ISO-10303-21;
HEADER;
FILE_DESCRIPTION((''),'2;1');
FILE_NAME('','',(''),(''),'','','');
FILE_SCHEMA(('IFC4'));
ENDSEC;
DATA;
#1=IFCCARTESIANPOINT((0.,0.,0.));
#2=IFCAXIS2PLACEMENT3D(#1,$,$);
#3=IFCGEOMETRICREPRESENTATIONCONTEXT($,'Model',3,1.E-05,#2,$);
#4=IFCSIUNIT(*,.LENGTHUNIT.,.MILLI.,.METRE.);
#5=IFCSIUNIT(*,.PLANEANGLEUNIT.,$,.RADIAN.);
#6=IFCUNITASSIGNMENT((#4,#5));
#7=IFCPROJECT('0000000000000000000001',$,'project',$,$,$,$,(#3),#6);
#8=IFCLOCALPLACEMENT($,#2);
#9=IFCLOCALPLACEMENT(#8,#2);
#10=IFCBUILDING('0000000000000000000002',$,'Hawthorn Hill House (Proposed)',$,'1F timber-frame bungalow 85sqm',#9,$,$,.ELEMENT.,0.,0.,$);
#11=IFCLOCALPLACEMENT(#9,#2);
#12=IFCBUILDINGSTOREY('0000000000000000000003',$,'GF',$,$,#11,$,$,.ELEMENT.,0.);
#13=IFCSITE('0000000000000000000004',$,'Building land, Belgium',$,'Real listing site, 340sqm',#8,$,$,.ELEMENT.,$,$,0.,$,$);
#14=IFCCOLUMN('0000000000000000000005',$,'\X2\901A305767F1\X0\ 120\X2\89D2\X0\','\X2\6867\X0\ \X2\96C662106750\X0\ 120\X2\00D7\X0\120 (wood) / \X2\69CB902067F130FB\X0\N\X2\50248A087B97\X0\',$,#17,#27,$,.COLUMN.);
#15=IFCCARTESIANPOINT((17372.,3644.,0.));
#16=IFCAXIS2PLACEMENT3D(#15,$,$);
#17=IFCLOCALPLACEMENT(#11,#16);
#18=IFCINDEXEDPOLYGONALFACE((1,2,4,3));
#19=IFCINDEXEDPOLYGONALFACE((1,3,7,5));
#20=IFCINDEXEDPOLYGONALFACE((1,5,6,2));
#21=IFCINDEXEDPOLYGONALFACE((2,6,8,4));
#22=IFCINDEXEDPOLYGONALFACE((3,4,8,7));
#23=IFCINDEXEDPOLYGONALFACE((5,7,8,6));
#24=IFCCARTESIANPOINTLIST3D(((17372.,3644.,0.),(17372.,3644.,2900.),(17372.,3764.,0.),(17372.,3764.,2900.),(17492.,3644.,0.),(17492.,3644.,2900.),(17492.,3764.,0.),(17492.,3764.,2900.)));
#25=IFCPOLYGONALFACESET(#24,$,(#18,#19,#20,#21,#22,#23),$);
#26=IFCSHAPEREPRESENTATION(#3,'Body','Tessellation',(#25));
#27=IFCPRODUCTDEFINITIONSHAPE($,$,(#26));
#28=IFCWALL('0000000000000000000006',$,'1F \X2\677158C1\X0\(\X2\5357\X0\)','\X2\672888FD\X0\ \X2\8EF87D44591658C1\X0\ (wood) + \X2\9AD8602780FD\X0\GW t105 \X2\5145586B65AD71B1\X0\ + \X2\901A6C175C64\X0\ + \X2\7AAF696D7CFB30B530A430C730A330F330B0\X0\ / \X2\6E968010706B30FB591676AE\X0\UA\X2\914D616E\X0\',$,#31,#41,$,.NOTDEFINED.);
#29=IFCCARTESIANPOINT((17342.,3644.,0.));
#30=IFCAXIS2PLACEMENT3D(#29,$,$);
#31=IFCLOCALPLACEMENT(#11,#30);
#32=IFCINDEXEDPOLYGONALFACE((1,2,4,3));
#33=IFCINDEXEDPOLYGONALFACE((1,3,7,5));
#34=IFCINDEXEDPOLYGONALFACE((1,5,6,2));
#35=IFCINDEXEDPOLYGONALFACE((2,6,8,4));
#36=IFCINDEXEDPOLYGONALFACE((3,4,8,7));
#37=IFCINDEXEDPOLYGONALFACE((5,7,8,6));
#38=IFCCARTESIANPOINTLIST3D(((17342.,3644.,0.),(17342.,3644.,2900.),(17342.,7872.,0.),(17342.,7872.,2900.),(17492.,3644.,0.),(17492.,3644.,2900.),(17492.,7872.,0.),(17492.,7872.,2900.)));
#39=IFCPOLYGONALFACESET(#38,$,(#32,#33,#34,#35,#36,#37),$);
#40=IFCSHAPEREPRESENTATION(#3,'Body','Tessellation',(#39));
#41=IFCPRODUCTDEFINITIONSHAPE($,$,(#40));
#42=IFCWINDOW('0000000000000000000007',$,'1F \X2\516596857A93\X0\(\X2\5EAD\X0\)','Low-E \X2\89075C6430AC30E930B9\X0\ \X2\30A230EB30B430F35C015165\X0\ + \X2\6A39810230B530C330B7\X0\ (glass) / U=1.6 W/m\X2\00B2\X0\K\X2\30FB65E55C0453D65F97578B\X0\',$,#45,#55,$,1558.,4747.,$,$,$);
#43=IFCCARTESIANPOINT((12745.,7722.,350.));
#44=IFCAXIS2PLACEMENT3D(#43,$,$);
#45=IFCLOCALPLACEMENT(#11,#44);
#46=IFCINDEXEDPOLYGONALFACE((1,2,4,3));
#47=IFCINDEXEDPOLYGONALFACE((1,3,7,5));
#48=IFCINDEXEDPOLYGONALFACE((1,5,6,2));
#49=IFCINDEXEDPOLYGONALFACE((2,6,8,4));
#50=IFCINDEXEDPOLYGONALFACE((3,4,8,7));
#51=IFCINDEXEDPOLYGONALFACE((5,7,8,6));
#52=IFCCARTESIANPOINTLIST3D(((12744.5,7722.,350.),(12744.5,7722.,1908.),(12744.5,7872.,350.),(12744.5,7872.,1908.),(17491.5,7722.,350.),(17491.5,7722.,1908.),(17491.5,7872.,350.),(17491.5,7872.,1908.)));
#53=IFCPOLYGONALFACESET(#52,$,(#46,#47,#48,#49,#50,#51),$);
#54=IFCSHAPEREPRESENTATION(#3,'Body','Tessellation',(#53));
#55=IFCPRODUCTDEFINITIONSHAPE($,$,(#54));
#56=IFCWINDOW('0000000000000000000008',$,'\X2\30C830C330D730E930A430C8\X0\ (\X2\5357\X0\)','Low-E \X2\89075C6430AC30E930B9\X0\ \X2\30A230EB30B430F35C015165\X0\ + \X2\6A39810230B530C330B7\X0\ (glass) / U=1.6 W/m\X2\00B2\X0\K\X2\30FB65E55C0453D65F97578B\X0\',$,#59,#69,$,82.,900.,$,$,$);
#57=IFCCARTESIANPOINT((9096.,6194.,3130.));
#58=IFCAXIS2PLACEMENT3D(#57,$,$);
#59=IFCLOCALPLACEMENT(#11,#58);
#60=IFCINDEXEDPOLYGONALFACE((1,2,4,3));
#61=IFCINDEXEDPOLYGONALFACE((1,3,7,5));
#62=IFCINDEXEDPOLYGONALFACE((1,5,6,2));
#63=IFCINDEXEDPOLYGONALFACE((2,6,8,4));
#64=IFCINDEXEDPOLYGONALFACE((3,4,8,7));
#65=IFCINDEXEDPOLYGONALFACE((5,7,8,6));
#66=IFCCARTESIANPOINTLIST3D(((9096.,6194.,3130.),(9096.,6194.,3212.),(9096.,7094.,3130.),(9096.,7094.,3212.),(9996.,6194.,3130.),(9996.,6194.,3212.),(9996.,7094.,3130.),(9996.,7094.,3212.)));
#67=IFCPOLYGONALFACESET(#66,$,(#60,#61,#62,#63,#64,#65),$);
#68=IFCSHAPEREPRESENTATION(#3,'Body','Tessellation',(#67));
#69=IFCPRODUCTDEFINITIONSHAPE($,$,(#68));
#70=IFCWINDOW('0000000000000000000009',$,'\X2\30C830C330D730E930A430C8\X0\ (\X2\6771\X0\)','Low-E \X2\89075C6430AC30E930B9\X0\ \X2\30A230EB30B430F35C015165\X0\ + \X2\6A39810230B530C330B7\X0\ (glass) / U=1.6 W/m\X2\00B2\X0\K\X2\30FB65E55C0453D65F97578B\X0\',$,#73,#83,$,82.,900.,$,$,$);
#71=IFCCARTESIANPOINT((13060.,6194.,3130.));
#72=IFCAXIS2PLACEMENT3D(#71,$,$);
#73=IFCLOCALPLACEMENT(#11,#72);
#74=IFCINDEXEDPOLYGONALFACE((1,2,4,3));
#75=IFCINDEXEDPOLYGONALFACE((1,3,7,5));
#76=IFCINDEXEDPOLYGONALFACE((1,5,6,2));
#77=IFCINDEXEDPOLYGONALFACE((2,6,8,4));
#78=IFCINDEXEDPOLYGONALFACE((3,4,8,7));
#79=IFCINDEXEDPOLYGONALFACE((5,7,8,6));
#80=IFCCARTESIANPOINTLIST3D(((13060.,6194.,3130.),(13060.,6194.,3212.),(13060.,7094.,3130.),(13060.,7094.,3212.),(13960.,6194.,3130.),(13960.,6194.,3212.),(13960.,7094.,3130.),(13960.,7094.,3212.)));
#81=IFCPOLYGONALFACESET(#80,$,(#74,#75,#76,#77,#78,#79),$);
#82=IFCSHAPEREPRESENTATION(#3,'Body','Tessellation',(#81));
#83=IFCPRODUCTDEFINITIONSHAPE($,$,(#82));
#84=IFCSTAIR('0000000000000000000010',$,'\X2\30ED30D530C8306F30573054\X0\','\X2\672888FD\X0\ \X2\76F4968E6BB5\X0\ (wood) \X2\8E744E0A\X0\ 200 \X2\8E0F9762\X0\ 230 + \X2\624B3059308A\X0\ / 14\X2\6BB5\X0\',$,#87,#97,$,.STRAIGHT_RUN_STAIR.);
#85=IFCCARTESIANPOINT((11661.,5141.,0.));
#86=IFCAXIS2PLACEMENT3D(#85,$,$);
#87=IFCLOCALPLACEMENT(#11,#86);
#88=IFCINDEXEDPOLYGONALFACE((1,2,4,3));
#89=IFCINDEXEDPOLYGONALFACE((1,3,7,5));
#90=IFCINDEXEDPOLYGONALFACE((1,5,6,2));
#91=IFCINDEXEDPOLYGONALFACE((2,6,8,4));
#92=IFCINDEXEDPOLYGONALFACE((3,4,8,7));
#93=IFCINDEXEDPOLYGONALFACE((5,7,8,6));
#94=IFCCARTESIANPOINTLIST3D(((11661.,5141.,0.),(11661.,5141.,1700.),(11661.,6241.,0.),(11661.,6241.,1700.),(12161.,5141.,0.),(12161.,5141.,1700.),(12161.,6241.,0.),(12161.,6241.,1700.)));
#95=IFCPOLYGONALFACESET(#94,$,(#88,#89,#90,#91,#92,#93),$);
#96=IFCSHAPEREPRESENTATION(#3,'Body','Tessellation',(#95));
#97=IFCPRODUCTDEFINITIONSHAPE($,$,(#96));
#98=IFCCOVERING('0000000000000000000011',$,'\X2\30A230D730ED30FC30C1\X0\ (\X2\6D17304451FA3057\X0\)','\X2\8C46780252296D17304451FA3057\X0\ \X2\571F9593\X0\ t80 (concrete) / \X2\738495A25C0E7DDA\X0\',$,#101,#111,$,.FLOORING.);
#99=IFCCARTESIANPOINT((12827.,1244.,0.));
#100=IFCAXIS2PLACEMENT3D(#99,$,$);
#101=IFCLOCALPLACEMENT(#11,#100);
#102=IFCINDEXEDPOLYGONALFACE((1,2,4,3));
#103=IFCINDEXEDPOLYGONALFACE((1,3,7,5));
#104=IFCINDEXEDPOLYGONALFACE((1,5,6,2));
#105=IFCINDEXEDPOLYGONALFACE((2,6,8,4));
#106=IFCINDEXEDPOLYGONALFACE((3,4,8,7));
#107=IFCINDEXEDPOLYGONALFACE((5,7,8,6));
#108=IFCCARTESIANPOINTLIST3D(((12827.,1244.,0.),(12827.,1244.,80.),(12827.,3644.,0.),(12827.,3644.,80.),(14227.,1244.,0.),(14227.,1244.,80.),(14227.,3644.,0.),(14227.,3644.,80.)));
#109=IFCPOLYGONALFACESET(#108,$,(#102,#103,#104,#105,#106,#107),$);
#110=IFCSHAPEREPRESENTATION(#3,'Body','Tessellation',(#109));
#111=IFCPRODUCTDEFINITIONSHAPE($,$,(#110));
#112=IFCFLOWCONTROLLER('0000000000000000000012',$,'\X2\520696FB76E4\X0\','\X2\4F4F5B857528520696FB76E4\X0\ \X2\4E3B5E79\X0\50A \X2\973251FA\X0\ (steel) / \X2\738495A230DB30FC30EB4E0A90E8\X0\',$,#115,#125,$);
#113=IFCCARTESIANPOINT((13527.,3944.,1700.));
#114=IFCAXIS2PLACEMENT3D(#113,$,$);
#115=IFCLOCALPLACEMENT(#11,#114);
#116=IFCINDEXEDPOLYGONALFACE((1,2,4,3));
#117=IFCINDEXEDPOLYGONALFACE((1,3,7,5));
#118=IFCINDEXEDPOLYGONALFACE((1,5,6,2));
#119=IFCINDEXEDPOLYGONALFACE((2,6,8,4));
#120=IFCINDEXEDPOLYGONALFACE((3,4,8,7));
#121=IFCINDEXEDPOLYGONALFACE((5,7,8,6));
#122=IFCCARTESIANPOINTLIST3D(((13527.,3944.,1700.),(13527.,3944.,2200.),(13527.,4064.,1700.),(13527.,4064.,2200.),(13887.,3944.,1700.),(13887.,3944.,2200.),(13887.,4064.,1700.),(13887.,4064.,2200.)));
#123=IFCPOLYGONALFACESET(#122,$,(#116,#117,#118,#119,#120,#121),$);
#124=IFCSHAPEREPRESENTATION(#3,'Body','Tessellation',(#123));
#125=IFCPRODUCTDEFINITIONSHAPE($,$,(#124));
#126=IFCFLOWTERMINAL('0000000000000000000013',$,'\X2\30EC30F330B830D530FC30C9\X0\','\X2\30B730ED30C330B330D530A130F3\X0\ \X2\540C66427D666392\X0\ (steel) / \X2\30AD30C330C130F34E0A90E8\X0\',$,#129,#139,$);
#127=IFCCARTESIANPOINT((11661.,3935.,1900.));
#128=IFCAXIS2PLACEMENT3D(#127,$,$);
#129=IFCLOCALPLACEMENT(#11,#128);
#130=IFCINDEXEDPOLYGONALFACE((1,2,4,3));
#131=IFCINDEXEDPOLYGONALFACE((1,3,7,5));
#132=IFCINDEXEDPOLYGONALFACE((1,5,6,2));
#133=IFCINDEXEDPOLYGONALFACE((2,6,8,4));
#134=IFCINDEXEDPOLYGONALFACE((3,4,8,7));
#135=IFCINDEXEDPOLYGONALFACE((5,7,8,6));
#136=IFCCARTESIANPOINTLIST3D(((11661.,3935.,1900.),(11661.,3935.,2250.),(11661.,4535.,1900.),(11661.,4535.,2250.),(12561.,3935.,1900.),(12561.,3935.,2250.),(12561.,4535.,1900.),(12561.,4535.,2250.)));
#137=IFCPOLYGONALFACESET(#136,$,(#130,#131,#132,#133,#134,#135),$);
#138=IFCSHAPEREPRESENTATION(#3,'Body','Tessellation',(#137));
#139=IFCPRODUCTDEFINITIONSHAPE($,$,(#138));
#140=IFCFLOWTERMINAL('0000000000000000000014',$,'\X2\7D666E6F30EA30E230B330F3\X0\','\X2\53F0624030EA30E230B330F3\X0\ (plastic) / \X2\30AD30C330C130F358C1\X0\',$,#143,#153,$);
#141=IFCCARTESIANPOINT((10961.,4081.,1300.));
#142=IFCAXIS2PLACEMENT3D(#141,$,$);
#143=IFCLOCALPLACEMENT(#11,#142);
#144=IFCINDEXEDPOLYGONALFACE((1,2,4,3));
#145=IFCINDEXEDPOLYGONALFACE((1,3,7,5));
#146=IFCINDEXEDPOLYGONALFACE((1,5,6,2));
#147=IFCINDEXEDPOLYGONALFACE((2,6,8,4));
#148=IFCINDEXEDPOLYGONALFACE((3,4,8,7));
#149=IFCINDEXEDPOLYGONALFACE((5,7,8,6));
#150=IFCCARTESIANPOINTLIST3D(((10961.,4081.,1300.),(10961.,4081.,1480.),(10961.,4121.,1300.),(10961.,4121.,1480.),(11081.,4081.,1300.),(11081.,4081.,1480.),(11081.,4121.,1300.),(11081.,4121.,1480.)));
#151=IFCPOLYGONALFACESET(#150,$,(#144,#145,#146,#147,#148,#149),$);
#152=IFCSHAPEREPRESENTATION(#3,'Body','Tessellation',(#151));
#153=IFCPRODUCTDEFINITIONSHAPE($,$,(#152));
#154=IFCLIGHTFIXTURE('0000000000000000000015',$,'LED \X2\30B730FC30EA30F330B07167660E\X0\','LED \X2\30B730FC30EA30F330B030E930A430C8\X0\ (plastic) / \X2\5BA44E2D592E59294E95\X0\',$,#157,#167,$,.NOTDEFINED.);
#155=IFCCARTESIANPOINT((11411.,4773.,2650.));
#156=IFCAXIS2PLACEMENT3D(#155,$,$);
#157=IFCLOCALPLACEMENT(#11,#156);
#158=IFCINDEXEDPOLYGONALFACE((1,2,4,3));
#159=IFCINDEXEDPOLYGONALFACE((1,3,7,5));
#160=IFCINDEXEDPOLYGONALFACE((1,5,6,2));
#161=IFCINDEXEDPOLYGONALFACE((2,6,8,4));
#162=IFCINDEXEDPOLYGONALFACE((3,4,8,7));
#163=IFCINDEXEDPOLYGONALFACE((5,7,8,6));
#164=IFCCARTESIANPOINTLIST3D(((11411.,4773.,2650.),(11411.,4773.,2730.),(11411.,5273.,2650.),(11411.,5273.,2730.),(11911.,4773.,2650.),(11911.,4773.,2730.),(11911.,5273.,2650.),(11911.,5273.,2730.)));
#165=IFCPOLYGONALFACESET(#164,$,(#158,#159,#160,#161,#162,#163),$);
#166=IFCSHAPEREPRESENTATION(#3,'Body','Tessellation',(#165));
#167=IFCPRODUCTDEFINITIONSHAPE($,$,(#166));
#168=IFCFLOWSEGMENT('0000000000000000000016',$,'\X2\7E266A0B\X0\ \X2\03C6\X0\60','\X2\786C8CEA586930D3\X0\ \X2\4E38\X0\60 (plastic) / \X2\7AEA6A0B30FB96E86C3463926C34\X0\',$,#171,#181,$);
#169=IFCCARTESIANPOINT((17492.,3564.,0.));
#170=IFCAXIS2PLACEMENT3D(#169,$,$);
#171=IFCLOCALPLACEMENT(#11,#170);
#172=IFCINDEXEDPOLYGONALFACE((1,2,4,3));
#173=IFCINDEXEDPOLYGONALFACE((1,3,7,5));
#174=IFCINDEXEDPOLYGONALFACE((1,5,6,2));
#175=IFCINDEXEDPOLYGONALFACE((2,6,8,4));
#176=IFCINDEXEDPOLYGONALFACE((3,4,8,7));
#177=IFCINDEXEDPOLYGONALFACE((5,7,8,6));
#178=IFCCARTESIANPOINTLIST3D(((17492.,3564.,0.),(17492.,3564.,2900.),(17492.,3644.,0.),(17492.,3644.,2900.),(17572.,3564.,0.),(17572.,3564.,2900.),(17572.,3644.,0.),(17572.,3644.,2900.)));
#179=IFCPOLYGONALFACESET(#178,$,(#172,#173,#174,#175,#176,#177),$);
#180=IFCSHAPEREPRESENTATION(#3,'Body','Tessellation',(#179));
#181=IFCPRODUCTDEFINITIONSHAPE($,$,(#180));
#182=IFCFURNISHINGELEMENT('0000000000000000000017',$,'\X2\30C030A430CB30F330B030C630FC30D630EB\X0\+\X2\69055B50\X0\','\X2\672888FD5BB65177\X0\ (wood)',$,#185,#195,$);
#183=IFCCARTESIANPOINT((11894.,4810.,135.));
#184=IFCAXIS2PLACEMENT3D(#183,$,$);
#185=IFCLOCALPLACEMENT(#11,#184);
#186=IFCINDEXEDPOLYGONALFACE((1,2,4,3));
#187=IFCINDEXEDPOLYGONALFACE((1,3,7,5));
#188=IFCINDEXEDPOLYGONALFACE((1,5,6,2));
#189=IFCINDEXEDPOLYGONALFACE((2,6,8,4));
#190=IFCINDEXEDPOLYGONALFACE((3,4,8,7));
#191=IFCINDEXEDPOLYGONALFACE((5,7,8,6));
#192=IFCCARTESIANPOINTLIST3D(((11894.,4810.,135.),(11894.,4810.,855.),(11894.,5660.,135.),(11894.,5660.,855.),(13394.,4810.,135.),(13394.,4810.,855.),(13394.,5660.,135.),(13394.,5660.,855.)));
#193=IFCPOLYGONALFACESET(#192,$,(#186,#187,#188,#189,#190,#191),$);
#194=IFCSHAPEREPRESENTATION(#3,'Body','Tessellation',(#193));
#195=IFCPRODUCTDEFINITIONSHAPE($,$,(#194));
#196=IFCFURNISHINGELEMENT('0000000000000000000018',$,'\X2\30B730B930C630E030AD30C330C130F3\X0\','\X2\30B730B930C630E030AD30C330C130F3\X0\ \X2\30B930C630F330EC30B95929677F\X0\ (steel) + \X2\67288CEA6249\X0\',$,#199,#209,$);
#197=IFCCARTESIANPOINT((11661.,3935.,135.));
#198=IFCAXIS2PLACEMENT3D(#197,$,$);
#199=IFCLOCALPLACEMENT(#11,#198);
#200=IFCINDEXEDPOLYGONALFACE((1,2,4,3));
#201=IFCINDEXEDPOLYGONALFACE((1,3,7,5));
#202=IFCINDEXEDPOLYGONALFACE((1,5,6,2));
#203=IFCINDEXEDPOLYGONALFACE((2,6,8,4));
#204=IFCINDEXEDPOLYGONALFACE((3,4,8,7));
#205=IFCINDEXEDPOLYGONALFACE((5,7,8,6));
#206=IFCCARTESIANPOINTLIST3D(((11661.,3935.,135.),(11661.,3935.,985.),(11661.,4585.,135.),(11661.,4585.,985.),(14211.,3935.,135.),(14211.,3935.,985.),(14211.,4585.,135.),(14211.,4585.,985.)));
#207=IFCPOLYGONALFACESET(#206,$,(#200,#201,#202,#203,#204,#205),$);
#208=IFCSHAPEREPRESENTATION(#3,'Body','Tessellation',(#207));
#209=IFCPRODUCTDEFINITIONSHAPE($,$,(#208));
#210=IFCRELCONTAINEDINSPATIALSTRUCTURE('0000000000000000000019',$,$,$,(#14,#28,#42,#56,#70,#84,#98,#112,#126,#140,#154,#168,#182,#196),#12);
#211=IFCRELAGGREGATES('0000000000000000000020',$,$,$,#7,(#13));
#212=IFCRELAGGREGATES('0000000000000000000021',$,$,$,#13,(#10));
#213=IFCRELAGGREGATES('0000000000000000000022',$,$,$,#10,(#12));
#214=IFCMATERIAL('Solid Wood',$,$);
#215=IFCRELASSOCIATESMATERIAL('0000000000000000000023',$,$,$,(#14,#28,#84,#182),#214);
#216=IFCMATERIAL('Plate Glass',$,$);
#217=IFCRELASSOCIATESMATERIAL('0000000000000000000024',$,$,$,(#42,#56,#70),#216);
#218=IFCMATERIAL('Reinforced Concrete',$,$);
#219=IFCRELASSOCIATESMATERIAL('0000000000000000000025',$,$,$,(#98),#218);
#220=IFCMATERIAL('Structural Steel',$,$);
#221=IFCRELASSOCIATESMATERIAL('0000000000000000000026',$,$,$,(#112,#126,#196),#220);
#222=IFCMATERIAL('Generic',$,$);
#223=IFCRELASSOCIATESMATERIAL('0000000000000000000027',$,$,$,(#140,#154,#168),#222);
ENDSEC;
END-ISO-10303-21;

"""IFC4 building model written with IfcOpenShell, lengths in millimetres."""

from ifc_helpers import new_model, si_unit, frame, frame_2d, origin, place, context, project, spatial, rectangle, extrude, material, element, fill, save


model = new_model("IFC4")

# Units and contexts
model_context = context("Model", 3, precision=1e-05, world=origin())
ifc_project = project(units=[si_unit("LENGTHUNIT", "METRE", prefix="MILLI"), si_unit("PLANEANGLEUNIT", "RADIAN")], contexts=[model_context])

# Site, building, storey
site_placement = place(None, origin())
site = spatial("IfcSite", under=ifc_project, at=site_placement, Name="Building land, Belgium", ObjectType="Real listing site, 340sqm", CompositionType="ELEMENT", RefElevation=0.0)
building_placement = place(site_placement, origin())
building = spatial("IfcBuilding", under=site, at=building_placement, Name="Hawthorn Hill House (Proposed)", ObjectType="1F timber-frame bungalow 85sqm", CompositionType="ELEMENT", ElevationOfRefHeight=0.0, ElevationOfTerrain=0.0)
storey_placement = place(building_placement, origin())
storey = spatial("IfcBuildingStorey", under=building, at=storey_placement, Name="GF", CompositionType="ELEMENT", Elevation=0.0)

# Column
ifc_material_1 = material(Name="Solid Wood")
column_1_placement = place(storey_placement, frame((17372.0, 3644.0, 0.0)))
element("IfcColumn", 1, at=column_1_placement, inside=storey, material=ifc_material_1, Name="通し柱 120角", Description="桧 集成材 120×120 (wood) / 構造柱・N値計算", PredefinedType="COLUMN", context=model_context, shape_type="SweptSolid", body=[
    extrude(rectangle(XDim=120.0, YDim=120.0, at=frame_2d((60.0, 60.0))), frame((17372.0, 3644.0, 0.0)), (0.0, 0.0, 1.0), 2900.0),
])

# Wall, opening, window
wall_1_placement = place(storey_placement, frame((17342.0, 3644.0, 0.0)))
wall_1 = element("IfcWall", 2, at=wall_1_placement, inside=storey, material=ifc_material_1, Name="1F 東壁(南)", Description="木製 軸組外壁 (wood) + 高性能GW t105 充填断熱 + 通気層 + 窯業系サイディング / 準耐火・外皮UA配慮", PredefinedType="NOTDEFINED", context=model_context, shape_type="SweptSolid", body=[
    extrude(rectangle(XDim=150.0, YDim=4228.0, at=frame_2d((75.0, 2114.0))), frame((17342.0, 3644.0, 0.0)), (0.0, 0.0, 1.0), 2900.0),
])
opening_1_placement = place(storey_placement, frame((12745.0, 7722.0, 350.0)))
opening_1 = element("IfcOpeningElement", 3, at=opening_1_placement, cuts=wall_1, PredefinedType="NOTDEFINED", context=model_context, shape_type="SweptSolid", body=[
    extrude(rectangle(XDim=4747.0, YDim=150.0, at=frame_2d((2373.0, 75.0))), frame((12745.0, 7722.0, 350.0)), (0.0, 0.0, 1.0), 1558.0),
])
ifc_material_2 = material(Name="Plate Glass")
window_1_placement = place(storey_placement, frame((12745.0, 7722.0, 350.0)))
window_1 = element("IfcWindow", 4, at=window_1_placement, inside=storey, material=ifc_material_2, Name="1F 入隅窓(庭)", Description="Low-E 複層ガラス アルゴン封入 + 樹脂サッシ (glass) / U=1.6 W/m²K・日射取得型", OverallHeight=1558.0, OverallWidth=4747.0, context=model_context, shape_type="SweptSolid", body=[
    extrude(rectangle(XDim=4747.0, YDim=150.0, at=frame_2d((2373.0, 75.0))), frame((12745.0, 7722.0, 350.0)), (0.0, 0.0, 1.0), 1558.0),
])
fill(opening_1, window_1)

# Windows
window_2_placement = place(storey_placement, frame((9096.0, 6194.0, 3130.0)))
element("IfcWindow", 5, at=window_2_placement, inside=storey, material=ifc_material_2, Name="トップライト (南)", Description="Low-E 複層ガラス アルゴン封入 + 樹脂サッシ (glass) / U=1.6 W/m²K・日射取得型", OverallHeight=82.0, OverallWidth=900.0, context=model_context, shape_type="SweptSolid", body=[
    extrude(rectangle(XDim=900.0, YDim=900.0, at=frame_2d((450.0, 450.0))), frame((9096.0, 6194.0, 3130.0)), (0.0, 0.0, 1.0), 82.0),
])
window_3_placement = place(storey_placement, frame((13060.0, 6194.0, 3130.0)))
element("IfcWindow", 6, at=window_3_placement, inside=storey, material=ifc_material_2, Name="トップライト (東)", Description="Low-E 複層ガラス アルゴン封入 + 樹脂サッシ (glass) / U=1.6 W/m²K・日射取得型", OverallHeight=82.0, OverallWidth=900.0, context=model_context, shape_type="SweptSolid", body=[
    extrude(rectangle(XDim=900.0, YDim=900.0, at=frame_2d((450.0, 450.0))), frame((13060.0, 6194.0, 3130.0)), (0.0, 0.0, 1.0), 82.0),
])

# Stair
stair_placement = place(storey_placement, frame((11661.0, 5141.0, 0.0)))
element("IfcStair", 7, at=stair_placement, inside=storey, material=ifc_material_1, Name="ロフトはしご", Description="木製 直階段 (wood) 蹴上 200 踏面 230 + 手すり / 14段", PredefinedType="STRAIGHT_RUN_STAIR", context=model_context, shape_type="SweptSolid", body=[
    extrude(rectangle(XDim=500.0, YDim=1100.0, at=frame_2d((250.0, 550.0))), frame((11661.0, 5141.0, 0.0)), (0.0, 0.0, 1.0), 1700.0),
])

# Covering
ifc_material_3 = material(Name="Reinforced Concrete")
covering_placement = place(storey_placement, frame((12827.0, 1244.0, 0.0)))
element("IfcCovering", 8, at=covering_placement, inside=storey, material=ifc_material_3, Name="アプローチ (洗い出し)", Description="豆砂利洗い出し 土間 t80 (concrete) / 玄関導線", PredefinedType="FLOORING", context=model_context, shape_type="SweptSolid", body=[
    extrude(rectangle(XDim=1400.0, YDim=2400.0, at=frame_2d((700.0, 1200.0))), frame((12827.0, 1244.0, 0.0)), (0.0, 0.0, 1.0), 80.0),
])

# Flow controller
ifc_material_4 = material(Name="Structural Steel")
flow_controller_placement = place(storey_placement, frame((13527.0, 3944.0, 1700.0)))
element("IfcFlowController", 9, at=flow_controller_placement, inside=storey, material=ifc_material_4, Name="分電盤", Description="住宅用分電盤 主幹50A 露出 (steel) / 玄関ホール上部", context=model_context, shape_type="SweptSolid", body=[
    extrude(rectangle(XDim=360.0, YDim=120.0, at=frame_2d((180.0, 60.0))), frame((13527.0, 3944.0, 1700.0)), (0.0, 0.0, 1.0), 500.0),
])

# Flow terminals
flow_terminal_1_placement = place(storey_placement, frame((11661.0, 3935.0, 1900.0)))
element("IfcFlowTerminal", 10, at=flow_terminal_1_placement, inside=storey, material=ifc_material_4, Name="レンジフード", Description="シロッコファン 同時給排 (steel) / キッチン上部", context=model_context, shape_type="SweptSolid", body=[
    extrude(rectangle(XDim=900.0, YDim=600.0, at=frame_2d((450.0, 300.0))), frame((11661.0, 3935.0, 1900.0)), (0.0, 0.0, 1.0), 350.0),
])
ifc_material_5 = material(Name="Generic")
flow_terminal_2_placement = place(storey_placement, frame((10961.0, 4081.0, 1300.0)))
element("IfcFlowTerminal", 11, at=flow_terminal_2_placement, inside=storey, material=ifc_material_5, Name="給湯リモコン", Description="台所リモコン (plastic) / キッチン壁", context=model_context, shape_type="SweptSolid", body=[
    extrude(rectangle(XDim=120.0, YDim=40.0, at=frame_2d((60.0, 20.0))), frame((10961.0, 4081.0, 1300.0)), (0.0, 0.0, 1.0), 180.0),
])

# Light fixture
light_fixture_placement = place(storey_placement, frame((11411.0, 4773.0, 2650.0)))
element("IfcLightFixture", 12, at=light_fixture_placement, inside=storey, material=ifc_material_5, Name="LED シーリング照明", Description="LED シーリングライト (plastic) / 室中央天井", PredefinedType="NOTDEFINED", context=model_context, shape_type="SweptSolid", body=[
    extrude(rectangle(XDim=500.0, YDim=500.0, at=frame_2d((250.0, 250.0))), frame((11411.0, 4773.0, 2650.0)), (0.0, 0.0, 1.0), 80.0),
])

# Flow segment
flow_segment_placement = place(storey_placement, frame((17492.0, 3564.0, 0.0)))
element("IfcFlowSegment", 13, at=flow_segment_placement, inside=storey, material=ifc_material_5, Name="縦樋 φ60", Description="硬質塩ビ 丸60 (plastic) / 竪樋・雨水排水", context=model_context, shape_type="SweptSolid", body=[
    extrude(rectangle(XDim=80.0, YDim=80.0, at=frame_2d((40.0, 40.0))), frame((17492.0, 3564.0, 0.0)), (0.0, 0.0, 1.0), 2900.0),
])

# Furnishing elements
furnishing_1_placement = place(storey_placement, frame((11894.0, 4810.0, 135.0)))
element("IfcFurnishingElement", 14, at=furnishing_1_placement, inside=storey, material=ifc_material_1, Name="ダイニングテーブル+椅子", Description="木製家具 (wood)", context=model_context, shape_type="SweptSolid", body=[
    extrude(rectangle(XDim=1500.0, YDim=850.0, at=frame_2d((750.0, 425.0))), frame((11894.0, 4810.0, 135.0)), (0.0, 0.0, 1.0), 720.0),
])
furnishing_2_placement = place(storey_placement, frame((11661.0, 3935.0, 135.0)))
element("IfcFurnishingElement", 15, at=furnishing_2_placement, inside=storey, material=ifc_material_4, Name="システムキッチン", Description="システムキッチン ステンレス天板 (steel) + 木質扉", context=model_context, shape_type="SweptSolid", body=[
    extrude(rectangle(XDim=2550.0, YDim=650.0, at=frame_2d((1275.0, 325.0))), frame((11661.0, 3935.0, 135.0)), (0.0, 0.0, 1.0), 850.0),
])

save(model, "model.ifc")
